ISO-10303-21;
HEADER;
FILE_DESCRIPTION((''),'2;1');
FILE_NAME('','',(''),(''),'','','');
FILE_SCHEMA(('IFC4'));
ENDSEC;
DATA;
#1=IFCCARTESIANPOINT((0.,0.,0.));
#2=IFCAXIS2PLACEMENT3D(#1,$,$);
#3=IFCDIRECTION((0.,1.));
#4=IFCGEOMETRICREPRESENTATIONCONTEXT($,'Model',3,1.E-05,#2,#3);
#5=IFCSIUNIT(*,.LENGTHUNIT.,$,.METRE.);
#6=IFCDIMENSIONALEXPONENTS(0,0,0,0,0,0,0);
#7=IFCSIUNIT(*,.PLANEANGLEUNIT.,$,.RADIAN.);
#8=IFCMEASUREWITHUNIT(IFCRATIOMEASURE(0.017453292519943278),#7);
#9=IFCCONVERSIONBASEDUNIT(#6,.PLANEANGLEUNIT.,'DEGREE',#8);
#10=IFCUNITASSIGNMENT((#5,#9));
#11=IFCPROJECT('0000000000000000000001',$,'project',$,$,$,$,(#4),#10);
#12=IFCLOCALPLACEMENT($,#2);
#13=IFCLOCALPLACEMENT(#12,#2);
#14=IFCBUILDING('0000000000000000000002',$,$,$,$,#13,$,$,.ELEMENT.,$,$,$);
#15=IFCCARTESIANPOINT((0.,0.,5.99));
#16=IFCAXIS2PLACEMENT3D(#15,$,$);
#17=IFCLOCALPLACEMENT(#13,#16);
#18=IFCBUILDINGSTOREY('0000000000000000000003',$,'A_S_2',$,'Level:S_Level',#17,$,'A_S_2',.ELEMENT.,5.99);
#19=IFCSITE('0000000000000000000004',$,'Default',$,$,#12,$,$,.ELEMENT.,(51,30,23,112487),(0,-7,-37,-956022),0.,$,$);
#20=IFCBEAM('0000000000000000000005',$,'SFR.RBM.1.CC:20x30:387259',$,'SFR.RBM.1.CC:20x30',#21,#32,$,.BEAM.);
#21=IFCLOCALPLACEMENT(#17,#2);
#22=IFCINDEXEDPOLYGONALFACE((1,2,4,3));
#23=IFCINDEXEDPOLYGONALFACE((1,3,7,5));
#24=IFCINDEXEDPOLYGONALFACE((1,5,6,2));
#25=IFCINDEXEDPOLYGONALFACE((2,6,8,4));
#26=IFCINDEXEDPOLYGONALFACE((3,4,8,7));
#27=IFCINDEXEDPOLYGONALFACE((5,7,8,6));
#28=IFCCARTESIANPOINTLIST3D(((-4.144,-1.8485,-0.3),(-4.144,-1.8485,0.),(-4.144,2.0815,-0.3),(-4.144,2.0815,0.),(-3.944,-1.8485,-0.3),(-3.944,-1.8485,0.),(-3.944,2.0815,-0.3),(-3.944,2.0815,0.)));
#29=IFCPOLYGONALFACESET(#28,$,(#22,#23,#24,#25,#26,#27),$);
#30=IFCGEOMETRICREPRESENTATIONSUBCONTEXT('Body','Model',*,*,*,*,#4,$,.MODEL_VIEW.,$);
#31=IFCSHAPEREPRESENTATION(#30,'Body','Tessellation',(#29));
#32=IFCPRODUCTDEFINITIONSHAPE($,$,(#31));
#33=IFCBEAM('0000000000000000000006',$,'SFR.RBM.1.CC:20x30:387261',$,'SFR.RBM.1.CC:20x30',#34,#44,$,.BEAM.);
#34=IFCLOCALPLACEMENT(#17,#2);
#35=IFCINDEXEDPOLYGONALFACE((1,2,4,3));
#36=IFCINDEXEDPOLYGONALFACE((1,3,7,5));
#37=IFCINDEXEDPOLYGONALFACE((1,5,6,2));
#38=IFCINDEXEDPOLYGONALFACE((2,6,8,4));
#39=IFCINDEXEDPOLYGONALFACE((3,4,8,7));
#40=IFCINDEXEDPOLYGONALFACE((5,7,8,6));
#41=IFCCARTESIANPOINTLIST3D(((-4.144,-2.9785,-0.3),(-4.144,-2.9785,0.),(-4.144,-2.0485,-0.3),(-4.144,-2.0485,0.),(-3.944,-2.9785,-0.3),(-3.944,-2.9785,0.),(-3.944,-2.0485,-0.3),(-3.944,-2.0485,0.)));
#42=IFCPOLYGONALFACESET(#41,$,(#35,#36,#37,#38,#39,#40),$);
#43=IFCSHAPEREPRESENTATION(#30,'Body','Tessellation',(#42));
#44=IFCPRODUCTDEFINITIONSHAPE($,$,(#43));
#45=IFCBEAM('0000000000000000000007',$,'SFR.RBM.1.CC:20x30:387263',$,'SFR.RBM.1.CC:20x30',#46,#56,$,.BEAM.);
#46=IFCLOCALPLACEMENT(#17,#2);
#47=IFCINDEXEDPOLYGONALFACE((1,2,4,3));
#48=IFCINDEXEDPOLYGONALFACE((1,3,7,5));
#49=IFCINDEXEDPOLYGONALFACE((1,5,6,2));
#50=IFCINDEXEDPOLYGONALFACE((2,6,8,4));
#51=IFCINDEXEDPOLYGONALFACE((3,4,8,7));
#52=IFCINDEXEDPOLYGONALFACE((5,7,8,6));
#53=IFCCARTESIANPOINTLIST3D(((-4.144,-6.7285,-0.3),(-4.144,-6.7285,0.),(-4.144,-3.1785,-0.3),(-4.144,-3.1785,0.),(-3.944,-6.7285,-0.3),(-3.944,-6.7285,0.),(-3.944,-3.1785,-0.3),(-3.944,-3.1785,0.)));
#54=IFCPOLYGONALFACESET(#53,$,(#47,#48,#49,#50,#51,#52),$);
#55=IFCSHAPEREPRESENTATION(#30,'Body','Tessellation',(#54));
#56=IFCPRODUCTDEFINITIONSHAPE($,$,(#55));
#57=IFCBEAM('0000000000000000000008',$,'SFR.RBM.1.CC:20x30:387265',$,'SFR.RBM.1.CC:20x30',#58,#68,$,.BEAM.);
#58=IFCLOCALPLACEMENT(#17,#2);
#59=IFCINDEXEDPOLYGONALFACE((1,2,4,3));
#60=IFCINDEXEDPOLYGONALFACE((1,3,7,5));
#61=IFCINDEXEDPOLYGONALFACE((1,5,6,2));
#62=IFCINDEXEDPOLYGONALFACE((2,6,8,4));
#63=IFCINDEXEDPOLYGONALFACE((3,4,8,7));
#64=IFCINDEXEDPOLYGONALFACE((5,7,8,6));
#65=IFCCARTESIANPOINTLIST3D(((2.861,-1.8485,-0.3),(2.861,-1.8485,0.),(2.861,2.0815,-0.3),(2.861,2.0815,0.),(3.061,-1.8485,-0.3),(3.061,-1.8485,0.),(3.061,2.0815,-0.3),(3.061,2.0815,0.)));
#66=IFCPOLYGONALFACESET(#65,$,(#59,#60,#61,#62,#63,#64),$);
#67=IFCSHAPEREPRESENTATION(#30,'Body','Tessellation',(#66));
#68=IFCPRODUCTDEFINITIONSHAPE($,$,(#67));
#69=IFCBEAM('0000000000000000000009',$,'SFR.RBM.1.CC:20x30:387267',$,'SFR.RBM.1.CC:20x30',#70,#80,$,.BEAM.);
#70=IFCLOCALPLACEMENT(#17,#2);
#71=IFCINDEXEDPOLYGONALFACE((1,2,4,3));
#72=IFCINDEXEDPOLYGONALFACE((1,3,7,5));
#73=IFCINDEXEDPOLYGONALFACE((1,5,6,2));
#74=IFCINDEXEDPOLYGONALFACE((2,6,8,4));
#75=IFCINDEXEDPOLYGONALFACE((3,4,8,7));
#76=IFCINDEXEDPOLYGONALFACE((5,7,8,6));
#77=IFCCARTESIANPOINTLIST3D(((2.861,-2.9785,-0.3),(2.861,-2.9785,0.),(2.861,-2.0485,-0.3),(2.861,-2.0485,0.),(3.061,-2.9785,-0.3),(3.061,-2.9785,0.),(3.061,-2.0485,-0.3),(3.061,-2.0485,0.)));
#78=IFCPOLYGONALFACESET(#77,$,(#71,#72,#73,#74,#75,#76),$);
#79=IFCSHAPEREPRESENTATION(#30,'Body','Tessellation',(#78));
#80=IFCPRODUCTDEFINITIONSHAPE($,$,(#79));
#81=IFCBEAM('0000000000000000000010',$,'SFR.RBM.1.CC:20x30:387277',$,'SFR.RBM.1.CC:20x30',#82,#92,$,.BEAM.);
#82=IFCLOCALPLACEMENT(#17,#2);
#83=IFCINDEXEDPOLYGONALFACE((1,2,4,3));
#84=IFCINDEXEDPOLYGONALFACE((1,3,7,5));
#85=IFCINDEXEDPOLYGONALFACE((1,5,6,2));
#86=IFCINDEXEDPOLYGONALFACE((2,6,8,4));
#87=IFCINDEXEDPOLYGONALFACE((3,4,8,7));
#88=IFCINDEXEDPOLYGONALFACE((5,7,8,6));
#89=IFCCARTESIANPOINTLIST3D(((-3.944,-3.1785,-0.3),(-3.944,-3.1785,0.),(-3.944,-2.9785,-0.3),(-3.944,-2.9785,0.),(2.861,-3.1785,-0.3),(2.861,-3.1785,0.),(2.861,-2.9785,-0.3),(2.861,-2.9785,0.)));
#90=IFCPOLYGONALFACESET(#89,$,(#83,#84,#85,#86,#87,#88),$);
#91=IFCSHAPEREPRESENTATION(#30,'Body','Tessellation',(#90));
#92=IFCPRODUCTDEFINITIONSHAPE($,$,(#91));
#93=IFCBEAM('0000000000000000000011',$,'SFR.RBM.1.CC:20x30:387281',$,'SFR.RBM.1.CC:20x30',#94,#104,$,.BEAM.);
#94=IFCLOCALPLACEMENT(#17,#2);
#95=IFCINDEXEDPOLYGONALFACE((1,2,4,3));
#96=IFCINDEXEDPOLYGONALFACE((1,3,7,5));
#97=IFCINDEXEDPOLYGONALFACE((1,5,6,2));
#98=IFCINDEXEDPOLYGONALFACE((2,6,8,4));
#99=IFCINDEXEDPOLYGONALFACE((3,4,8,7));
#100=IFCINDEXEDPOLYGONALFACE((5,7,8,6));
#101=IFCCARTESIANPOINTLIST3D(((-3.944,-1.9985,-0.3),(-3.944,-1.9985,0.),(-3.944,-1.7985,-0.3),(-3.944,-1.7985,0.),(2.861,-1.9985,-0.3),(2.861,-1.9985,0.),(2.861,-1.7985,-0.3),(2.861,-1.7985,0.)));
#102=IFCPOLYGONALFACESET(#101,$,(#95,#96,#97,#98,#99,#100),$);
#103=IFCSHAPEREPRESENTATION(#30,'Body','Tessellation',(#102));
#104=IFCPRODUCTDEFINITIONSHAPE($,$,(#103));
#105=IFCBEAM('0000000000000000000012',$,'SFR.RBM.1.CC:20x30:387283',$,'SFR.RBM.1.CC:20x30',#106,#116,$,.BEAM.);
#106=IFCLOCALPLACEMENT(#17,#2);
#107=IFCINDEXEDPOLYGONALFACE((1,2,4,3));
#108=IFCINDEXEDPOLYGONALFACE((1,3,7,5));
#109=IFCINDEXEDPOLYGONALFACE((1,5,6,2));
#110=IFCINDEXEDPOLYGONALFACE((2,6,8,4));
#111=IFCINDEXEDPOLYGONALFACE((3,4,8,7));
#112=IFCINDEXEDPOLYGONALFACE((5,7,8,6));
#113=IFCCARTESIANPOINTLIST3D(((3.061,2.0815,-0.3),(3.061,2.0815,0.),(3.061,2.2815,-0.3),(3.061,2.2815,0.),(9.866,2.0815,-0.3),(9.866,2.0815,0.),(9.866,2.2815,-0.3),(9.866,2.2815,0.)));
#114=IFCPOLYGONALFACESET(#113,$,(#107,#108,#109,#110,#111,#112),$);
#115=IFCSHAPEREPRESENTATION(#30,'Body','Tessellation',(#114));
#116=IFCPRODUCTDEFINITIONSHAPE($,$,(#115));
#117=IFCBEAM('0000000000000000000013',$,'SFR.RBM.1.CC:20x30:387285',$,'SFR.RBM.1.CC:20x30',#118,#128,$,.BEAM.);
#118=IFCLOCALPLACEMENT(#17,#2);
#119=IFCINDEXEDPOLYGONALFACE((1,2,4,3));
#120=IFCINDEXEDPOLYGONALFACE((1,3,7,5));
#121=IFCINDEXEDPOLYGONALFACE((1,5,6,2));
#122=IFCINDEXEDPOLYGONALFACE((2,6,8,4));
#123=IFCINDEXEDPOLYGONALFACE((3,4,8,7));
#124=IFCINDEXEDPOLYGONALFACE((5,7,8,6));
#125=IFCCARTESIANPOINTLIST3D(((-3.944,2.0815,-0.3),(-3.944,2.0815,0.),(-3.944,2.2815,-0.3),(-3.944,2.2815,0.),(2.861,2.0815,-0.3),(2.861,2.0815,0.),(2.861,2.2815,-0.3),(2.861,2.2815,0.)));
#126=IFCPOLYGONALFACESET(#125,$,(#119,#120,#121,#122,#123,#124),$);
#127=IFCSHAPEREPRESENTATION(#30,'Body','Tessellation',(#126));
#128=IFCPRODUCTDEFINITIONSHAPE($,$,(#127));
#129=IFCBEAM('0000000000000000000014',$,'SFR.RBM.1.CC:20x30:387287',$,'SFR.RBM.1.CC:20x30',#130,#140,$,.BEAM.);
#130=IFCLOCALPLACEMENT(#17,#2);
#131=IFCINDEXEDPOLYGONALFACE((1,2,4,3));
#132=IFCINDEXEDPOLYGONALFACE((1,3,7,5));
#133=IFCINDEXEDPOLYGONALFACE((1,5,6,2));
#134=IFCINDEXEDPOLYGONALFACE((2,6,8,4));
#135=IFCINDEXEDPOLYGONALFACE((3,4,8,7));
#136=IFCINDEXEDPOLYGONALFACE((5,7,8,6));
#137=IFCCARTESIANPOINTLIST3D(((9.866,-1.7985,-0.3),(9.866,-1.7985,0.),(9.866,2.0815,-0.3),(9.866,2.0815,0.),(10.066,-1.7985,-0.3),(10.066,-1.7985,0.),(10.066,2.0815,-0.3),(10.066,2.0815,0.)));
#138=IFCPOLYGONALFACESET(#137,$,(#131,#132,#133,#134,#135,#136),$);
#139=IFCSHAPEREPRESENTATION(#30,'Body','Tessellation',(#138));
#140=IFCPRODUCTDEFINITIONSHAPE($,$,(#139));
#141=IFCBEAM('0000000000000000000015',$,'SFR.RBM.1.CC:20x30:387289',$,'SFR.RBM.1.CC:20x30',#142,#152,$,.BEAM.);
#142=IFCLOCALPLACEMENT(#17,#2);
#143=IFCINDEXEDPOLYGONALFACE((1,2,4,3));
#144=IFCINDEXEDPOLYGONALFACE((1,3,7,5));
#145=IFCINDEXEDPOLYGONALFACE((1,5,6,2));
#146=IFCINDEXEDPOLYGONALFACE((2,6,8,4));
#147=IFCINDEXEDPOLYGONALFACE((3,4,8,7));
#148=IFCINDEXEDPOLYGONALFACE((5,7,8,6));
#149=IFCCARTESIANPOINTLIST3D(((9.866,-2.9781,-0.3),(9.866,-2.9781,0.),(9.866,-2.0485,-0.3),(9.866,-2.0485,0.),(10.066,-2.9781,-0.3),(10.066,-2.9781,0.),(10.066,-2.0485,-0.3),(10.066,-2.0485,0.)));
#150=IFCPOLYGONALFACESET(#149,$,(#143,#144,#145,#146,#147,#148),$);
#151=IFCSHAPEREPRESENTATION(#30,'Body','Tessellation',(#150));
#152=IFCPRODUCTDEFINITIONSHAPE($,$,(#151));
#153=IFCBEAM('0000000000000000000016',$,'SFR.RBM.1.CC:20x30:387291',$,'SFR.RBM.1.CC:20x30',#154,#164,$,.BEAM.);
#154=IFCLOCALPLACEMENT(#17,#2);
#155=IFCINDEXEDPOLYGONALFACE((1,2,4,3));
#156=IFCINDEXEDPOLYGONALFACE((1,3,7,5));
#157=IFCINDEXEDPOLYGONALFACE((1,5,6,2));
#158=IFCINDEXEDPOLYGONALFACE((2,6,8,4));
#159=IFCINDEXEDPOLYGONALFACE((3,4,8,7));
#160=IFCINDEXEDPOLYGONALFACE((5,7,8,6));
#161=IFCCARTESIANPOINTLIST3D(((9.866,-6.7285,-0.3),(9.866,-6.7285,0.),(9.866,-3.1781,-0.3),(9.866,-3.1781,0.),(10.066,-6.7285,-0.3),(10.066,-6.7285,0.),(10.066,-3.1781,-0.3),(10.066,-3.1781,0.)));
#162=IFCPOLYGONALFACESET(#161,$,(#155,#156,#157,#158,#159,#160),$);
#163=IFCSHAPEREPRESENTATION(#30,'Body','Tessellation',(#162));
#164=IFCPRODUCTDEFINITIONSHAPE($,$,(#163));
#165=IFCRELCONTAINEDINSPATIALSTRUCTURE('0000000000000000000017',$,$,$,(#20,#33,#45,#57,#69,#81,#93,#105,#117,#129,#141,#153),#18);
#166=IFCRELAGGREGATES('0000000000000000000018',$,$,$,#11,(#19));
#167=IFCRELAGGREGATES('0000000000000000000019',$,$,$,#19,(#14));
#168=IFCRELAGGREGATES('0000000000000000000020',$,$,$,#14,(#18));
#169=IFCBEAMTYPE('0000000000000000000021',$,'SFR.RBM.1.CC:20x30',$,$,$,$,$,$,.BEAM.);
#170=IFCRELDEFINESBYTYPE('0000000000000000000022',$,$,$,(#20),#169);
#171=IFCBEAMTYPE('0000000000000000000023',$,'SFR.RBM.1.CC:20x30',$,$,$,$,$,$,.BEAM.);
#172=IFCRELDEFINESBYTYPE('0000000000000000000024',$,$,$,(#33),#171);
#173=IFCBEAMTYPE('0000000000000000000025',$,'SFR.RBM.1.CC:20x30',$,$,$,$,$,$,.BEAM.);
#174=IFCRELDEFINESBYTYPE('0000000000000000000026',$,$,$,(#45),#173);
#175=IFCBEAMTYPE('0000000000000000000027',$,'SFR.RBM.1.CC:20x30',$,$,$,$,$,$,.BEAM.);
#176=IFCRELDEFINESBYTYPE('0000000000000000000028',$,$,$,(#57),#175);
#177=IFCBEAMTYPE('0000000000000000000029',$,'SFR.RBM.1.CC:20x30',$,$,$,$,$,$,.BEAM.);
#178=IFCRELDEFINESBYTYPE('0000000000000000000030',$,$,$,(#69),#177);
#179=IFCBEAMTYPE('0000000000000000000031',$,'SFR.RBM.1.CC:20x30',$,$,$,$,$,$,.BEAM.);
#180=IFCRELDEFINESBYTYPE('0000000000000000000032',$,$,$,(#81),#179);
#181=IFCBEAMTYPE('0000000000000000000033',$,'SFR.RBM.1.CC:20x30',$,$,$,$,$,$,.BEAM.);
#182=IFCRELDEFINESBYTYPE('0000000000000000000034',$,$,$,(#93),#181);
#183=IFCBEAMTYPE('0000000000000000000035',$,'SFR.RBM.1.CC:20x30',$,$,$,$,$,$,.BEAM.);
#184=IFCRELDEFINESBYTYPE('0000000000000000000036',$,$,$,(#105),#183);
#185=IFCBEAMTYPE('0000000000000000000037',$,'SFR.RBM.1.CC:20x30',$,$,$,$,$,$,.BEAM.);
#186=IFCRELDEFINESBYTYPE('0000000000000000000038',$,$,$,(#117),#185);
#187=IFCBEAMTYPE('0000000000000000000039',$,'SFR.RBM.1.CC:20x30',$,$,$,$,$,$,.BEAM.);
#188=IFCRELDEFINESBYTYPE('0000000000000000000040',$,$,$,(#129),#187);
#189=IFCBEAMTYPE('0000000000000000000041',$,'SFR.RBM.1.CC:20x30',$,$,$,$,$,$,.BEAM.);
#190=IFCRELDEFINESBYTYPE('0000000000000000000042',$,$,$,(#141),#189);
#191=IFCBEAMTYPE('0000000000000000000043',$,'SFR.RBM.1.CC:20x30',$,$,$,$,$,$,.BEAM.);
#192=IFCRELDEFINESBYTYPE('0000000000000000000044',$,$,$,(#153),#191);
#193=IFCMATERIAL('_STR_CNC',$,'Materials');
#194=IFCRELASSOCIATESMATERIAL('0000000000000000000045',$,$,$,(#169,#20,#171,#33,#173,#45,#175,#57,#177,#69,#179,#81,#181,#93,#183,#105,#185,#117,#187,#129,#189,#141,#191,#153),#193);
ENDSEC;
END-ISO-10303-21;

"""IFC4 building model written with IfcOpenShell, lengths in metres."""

from ifc_helpers import new_model, entity, si_unit, converted_unit, direction, frame, origin, place, context, subcontext, project, spatial, indexed_curve, outline, extrude, source, transform, mapped, material, type_object, type_shapes, element, save


model = new_model("IFC4")

# Units and contexts
model_context = context("Model", 3, precision=1e-05, world=origin(), true_north=direction((0.0, 1.0)))
body_context = subcontext(model_context, "Body", "Model", "MODEL_VIEW")
ifc_project = project(units=[si_unit("LENGTHUNIT", "METRE"), converted_unit("PLANEANGLEUNIT", "DEGREE", entity("IfcRatioMeasure", 0.017453292519943278), si_unit("PLANEANGLEUNIT", "RADIAN"), dimensions=[0, 0, 0, 0, 0, 0, 0])], contexts=[model_context])

# Site, building, storey
site_placement = place(None, origin())
site = spatial("IfcSite", under=ifc_project, at=site_placement, Name="Default", CompositionType="ELEMENT", RefLatitude=(51, 30, 23, 112487), RefLongitude=(0, -7, -37, -956022), RefElevation=0.0)
building_placement = place(site_placement, origin())
building = spatial("IfcBuilding", under=site, at=building_placement, CompositionType="ELEMENT")
storey_placement = place(building_placement, frame((0.0, 0.0, 5.99)))
storey = spatial("IfcBuildingStorey", under=building, at=storey_placement, Name="A_S_2", ObjectType="Level:S_Level", LongName="A_S_2", CompositionType="ELEMENT", Elevation=5.99)

# Beams
ifc_material_1 = material(Name="_STR_CNC", Category="Materials")
beam_type_1 = type_object("IfcBeamType", Name="SFR.RBM.1.CC:20x30", PredefinedType="BEAM", material=ifc_material_1)
shared_shape_1 = source(origin(), body_context, "Body", "SweptSolid", [
    extrude(outline(indexed_curve([(-0.1, -0.15), (0.1, -0.15), (0.1, 0.15), (-0.1, 0.15), (-0.1, -0.15)], self_intersect=False)), frame((-4.044, 2.0815, 5.84), z_axis=(0.0, -1.0, 0.0), x_axis=(-1.0, 0.0, 0.0)), (0.0, 0.0, 1.0), 3.93),
])
type_shapes(beam_type_1, [shared_shape_1])
beam_1_placement = place(storey_placement, frame((0.0, 0.0, -5.99)))
element("IfcBeam", 1, at=beam_1_placement, inside=storey, type_object=beam_type_1, material=ifc_material_1, Name="SFR.RBM.1.CC:20x30:387259", ObjectType="SFR.RBM.1.CC:20x30", PredefinedType="BEAM", context=body_context, shape_type="MappedRepresentation", body=[
    mapped(shared_shape_1, transform((0.0, 0.0, 0.0), scale=1.0)),
])
beam_type_2 = type_object("IfcBeamType", Name="SFR.RBM.1.CC:20x30", PredefinedType="BEAM", material=ifc_material_1)
shared_shape_2 = source(origin(), body_context, "Body", "SweptSolid", [
    extrude(outline(indexed_curve([(-0.1, -0.15), (0.1, -0.15), (0.1, 0.15), (-0.1, 0.15), (-0.1, -0.15)], self_intersect=False)), frame((-4.044, -2.0485, 5.84), z_axis=(0.0, -1.0, 0.0), x_axis=(-1.0, 0.0, 0.0)), (0.0, 0.0, 1.0), 0.93),
])
type_shapes(beam_type_2, [shared_shape_2])
beam_2_placement = place(storey_placement, frame((0.0, 0.0, -5.99)))
element("IfcBeam", 2, at=beam_2_placement, inside=storey, type_object=beam_type_2, material=ifc_material_1, Name="SFR.RBM.1.CC:20x30:387261", ObjectType="SFR.RBM.1.CC:20x30", PredefinedType="BEAM", context=body_context, shape_type="MappedRepresentation", body=[
    mapped(shared_shape_2, transform((0.0, 0.0, 0.0), scale=1.0)),
])
beam_type_3 = type_object("IfcBeamType", Name="SFR.RBM.1.CC:20x30", PredefinedType="BEAM", material=ifc_material_1)
shared_shape_3 = source(origin(), body_context, "Body", "SweptSolid", [
    extrude(outline(indexed_curve([(-0.1, -0.15), (0.1, -0.15), (0.1, 0.15), (-0.1, 0.15), (-0.1, -0.15)], self_intersect=False)), frame((-4.044, -3.1785, 5.84), z_axis=(0.0, -1.0, 0.0), x_axis=(-1.0, 0.0, 0.0)), (0.0, 0.0, 1.0), 3.55),
])
type_shapes(beam_type_3, [shared_shape_3])
beam_3_placement = place(storey_placement, frame((0.0, 0.0, -5.99)))
element("IfcBeam", 3, at=beam_3_placement, inside=storey, type_object=beam_type_3, material=ifc_material_1, Name="SFR.RBM.1.CC:20x30:387263", ObjectType="SFR.RBM.1.CC:20x30", PredefinedType="BEAM", context=body_context, shape_type="MappedRepresentation", body=[
    mapped(shared_shape_3, transform((0.0, 0.0, 0.0), scale=1.0)),
])
beam_type_4 = type_object("IfcBeamType", Name="SFR.RBM.1.CC:20x30", PredefinedType="BEAM", material=ifc_material_1)
shared_shape_4 = source(origin(), body_context, "Body", "SweptSolid", [
    extrude(outline(indexed_curve([(-0.1, -0.15), (0.1, -0.15), (0.1, 0.15), (-0.1, 0.15), (-0.1, -0.15)], self_intersect=False)), frame((2.961, 2.0815, 5.84), z_axis=(0.0, -1.0, 0.0), x_axis=(-1.0, 0.0, 0.0)), (0.0, 0.0, 1.0), 3.93),
])
type_shapes(beam_type_4, [shared_shape_4])
beam_4_placement = place(storey_placement, frame((0.0, 0.0, -5.99)))
element("IfcBeam", 4, at=beam_4_placement, inside=storey, type_object=beam_type_4, material=ifc_material_1, Name="SFR.RBM.1.CC:20x30:387265", ObjectType="SFR.RBM.1.CC:20x30", PredefinedType="BEAM", context=body_context, shape_type="MappedRepresentation", body=[
    mapped(shared_shape_4, transform((0.0, 0.0, 0.0), scale=1.0)),
])
beam_type_5 = type_object("IfcBeamType", Name="SFR.RBM.1.CC:20x30", PredefinedType="BEAM", material=ifc_material_1)
shared_shape_5 = source(origin(), body_context, "Body", "SweptSolid", [
    extrude(outline(indexed_curve([(-0.1, -0.15), (0.1, -0.15), (0.1, 0.15), (-0.1, 0.15), (-0.1, -0.15)], self_intersect=False)), frame((2.961, -2.0485, 5.84), z_axis=(0.0, -1.0, 0.0), x_axis=(-1.0, 0.0, 0.0)), (0.0, 0.0, 1.0), 0.93),
])
type_shapes(beam_type_5, [shared_shape_5])
beam_5_placement = place(storey_placement, frame((0.0, 0.0, -5.99)))
element("IfcBeam", 5, at=beam_5_placement, inside=storey, type_object=beam_type_5, material=ifc_material_1, Name="SFR.RBM.1.CC:20x30:387267", ObjectType="SFR.RBM.1.CC:20x30", PredefinedType="BEAM", context=body_context, shape_type="MappedRepresentation", body=[
    mapped(shared_shape_5, transform((0.0, 0.0, 0.0), scale=1.0)),
])
beam_type_6 = type_object("IfcBeamType", Name="SFR.RBM.1.CC:20x30", PredefinedType="BEAM", material=ifc_material_1)
shared_shape_6 = source(origin(), body_context, "Body", "SweptSolid", [
    extrude(outline(indexed_curve([(-0.15, -0.1), (0.15, -0.1), (0.15, 0.1), (-0.15, 0.1), (-0.15, -0.1)], self_intersect=False)), frame((2.861, -3.0785, 5.84), z_axis=(-1.0, 0.0, 0.0), x_axis=(0.0, 0.0, -1.0)), (0.0, 0.0, 1.0), 6.805),
])
type_shapes(beam_type_6, [shared_shape_6])
beam_6_placement = place(storey_placement, frame((0.0, 0.0, -5.99)))
element("IfcBeam", 6, at=beam_6_placement, inside=storey, type_object=beam_type_6, material=ifc_material_1, Name="SFR.RBM.1.CC:20x30:387277", ObjectType="SFR.RBM.1.CC:20x30", PredefinedType="BEAM", context=body_context, shape_type="MappedRepresentation", body=[
    mapped(shared_shape_6, transform((0.0, 0.0, 0.0), scale=1.0)),
])
beam_type_7 = type_object("IfcBeamType", Name="SFR.RBM.1.CC:20x30", PredefinedType="BEAM", material=ifc_material_1)
shared_shape_7 = source(origin(), body_context, "Body", "SweptSolid", [
    extrude(outline(indexed_curve([(-0.15, -0.1), (0.15, -0.1), (0.15, 0.1), (-0.15, 0.1), (-0.15, -0.1)], self_intersect=False)), frame((2.861, -1.8985, 5.84), z_axis=(-1.0, 0.0, 0.0), x_axis=(0.0, 0.0, -1.0)), (0.0, 0.0, 1.0), 6.805),
])
type_shapes(beam_type_7, [shared_shape_7])
beam_7_placement = place(storey_placement, frame((0.0, 0.0, -5.99)))
element("IfcBeam", 7, at=beam_7_placement, inside=storey, type_object=beam_type_7, material=ifc_material_1, Name="SFR.RBM.1.CC:20x30:387281", ObjectType="SFR.RBM.1.CC:20x30", PredefinedType="BEAM", context=body_context, shape_type="MappedRepresentation", body=[
    mapped(shared_shape_7, transform((0.0, 0.0, 0.0), scale=1.0)),
])
beam_type_8 = type_object("IfcBeamType", Name="SFR.RBM.1.CC:20x30", PredefinedType="BEAM", material=ifc_material_1)
shared_shape_8 = source(origin(), body_context, "Body", "SweptSolid", [
    extrude(outline(indexed_curve([(-0.15, -0.1), (0.15, -0.1), (0.15, 0.1), (-0.15, 0.1), (-0.15, -0.1)], self_intersect=False)), frame((9.866, 2.1815, 5.84), z_axis=(-1.0, 0.0, 0.0), x_axis=(0.0, 0.0, -1.0)), (0.0, 0.0, 1.0), 6.805),
])
type_shapes(beam_type_8, [shared_shape_8])
beam_8_placement = place(storey_placement, frame((0.0, 0.0, -5.99)))
element("IfcBeam", 8, at=beam_8_placement, inside=storey, type_object=beam_type_8, material=ifc_material_1, Name="SFR.RBM.1.CC:20x30:387283", ObjectType="SFR.RBM.1.CC:20x30", PredefinedType="BEAM", context=body_context, shape_type="MappedRepresentation", body=[
    mapped(shared_shape_8, transform((0.0, 0.0, 0.0), scale=1.0)),
])
beam_type_9 = type_object("IfcBeamType", Name="SFR.RBM.1.CC:20x30", PredefinedType="BEAM", material=ifc_material_1)
shared_shape_9 = source(origin(), body_context, "Body", "SweptSolid", [
    extrude(outline(indexed_curve([(-0.15, -0.1), (0.15, -0.1), (0.15, 0.1), (-0.15, 0.1), (-0.15, -0.1)], self_intersect=False)), frame((2.861, 2.1815, 5.84), z_axis=(-1.0, 0.0, 0.0), x_axis=(0.0, 0.0, -1.0)), (0.0, 0.0, 1.0), 6.805),
])
type_shapes(beam_type_9, [shared_shape_9])
beam_9_placement = place(storey_placement, frame((0.0, 0.0, -5.99)))
element("IfcBeam", 9, at=beam_9_placement, inside=storey, type_object=beam_type_9, material=ifc_material_1, Name="SFR.RBM.1.CC:20x30:387285", ObjectType="SFR.RBM.1.CC:20x30", PredefinedType="BEAM", context=body_context, shape_type="MappedRepresentation", body=[
    mapped(shared_shape_9, transform((0.0, 0.0, 0.0), scale=1.0)),
])
beam_type_10 = type_object("IfcBeamType", Name="SFR.RBM.1.CC:20x30", PredefinedType="BEAM", material=ifc_material_1)
shared_shape_10 = source(origin(), body_context, "Body", "SweptSolid", [
    extrude(outline(indexed_curve([(-0.1, -0.15), (0.1, -0.15), (0.1, 0.15), (-0.1, 0.15), (-0.1, -0.15)], self_intersect=False)), frame((9.966, 2.0815, 5.84), z_axis=(0.0, -1.0, 0.0), x_axis=(-1.0, 0.0, 0.0)), (0.0, 0.0, 1.0), 3.88),
])
type_shapes(beam_type_10, [shared_shape_10])
beam_10_placement = place(storey_placement, frame((0.0, 0.0, -5.99)))
element("IfcBeam", 10, at=beam_10_placement, inside=storey, type_object=beam_type_10, material=ifc_material_1, Name="SFR.RBM.1.CC:20x30:387287", ObjectType="SFR.RBM.1.CC:20x30", PredefinedType="BEAM", context=body_context, shape_type="MappedRepresentation", body=[
    mapped(shared_shape_10, transform((0.0, 0.0, 0.0), scale=1.0)),
])
beam_type_11 = type_object("IfcBeamType", Name="SFR.RBM.1.CC:20x30", PredefinedType="BEAM", material=ifc_material_1)
shared_shape_11 = source(origin(), body_context, "Body", "SweptSolid", [
    extrude(outline(indexed_curve([(-0.1, -0.15), (0.1, -0.15), (0.1, 0.15), (-0.1, 0.15), (-0.1, -0.15)], self_intersect=False)), frame((9.966, -2.0485, 5.84), z_axis=(0.0, -1.0, 0.0), x_axis=(-1.0, 0.0, 0.0)), (0.0, 0.0, 1.0), 0.9296),
])
type_shapes(beam_type_11, [shared_shape_11])
beam_11_placement = place(storey_placement, frame((0.0, 0.0, -5.99)))
element("IfcBeam", 11, at=beam_11_placement, inside=storey, type_object=beam_type_11, material=ifc_material_1, Name="SFR.RBM.1.CC:20x30:387289", ObjectType="SFR.RBM.1.CC:20x30", PredefinedType="BEAM", context=body_context, shape_type="MappedRepresentation", body=[
    mapped(shared_shape_11, transform((0.0, 0.0, 0.0), scale=1.0)),
])
beam_type_12 = type_object("IfcBeamType", Name="SFR.RBM.1.CC:20x30", PredefinedType="BEAM", material=ifc_material_1)
shared_shape_12 = source(origin(), body_context, "Body", "SweptSolid", [
    extrude(outline(indexed_curve([(-0.1, -0.15), (0.1, -0.15), (0.1, 0.15), (-0.1, 0.15), (-0.1, -0.15)], self_intersect=False)), frame((9.966, -3.1781, 5.84), z_axis=(0.0, -1.0, 0.0), x_axis=(-1.0, 0.0, 0.0)), (0.0, 0.0, 1.0), 3.5504),
])
type_shapes(beam_type_12, [shared_shape_12])
beam_12_placement = place(storey_placement, frame((0.0, 0.0, -5.99)))
element("IfcBeam", 12, at=beam_12_placement, inside=storey, type_object=beam_type_12, material=ifc_material_1, Name="SFR.RBM.1.CC:20x30:387291", ObjectType="SFR.RBM.1.CC:20x30", PredefinedType="BEAM", context=body_context, shape_type="MappedRepresentation", body=[
    mapped(shared_shape_12, transform((0.0, 0.0, 0.0), scale=1.0)),
])

save(model, "model.ifc")
